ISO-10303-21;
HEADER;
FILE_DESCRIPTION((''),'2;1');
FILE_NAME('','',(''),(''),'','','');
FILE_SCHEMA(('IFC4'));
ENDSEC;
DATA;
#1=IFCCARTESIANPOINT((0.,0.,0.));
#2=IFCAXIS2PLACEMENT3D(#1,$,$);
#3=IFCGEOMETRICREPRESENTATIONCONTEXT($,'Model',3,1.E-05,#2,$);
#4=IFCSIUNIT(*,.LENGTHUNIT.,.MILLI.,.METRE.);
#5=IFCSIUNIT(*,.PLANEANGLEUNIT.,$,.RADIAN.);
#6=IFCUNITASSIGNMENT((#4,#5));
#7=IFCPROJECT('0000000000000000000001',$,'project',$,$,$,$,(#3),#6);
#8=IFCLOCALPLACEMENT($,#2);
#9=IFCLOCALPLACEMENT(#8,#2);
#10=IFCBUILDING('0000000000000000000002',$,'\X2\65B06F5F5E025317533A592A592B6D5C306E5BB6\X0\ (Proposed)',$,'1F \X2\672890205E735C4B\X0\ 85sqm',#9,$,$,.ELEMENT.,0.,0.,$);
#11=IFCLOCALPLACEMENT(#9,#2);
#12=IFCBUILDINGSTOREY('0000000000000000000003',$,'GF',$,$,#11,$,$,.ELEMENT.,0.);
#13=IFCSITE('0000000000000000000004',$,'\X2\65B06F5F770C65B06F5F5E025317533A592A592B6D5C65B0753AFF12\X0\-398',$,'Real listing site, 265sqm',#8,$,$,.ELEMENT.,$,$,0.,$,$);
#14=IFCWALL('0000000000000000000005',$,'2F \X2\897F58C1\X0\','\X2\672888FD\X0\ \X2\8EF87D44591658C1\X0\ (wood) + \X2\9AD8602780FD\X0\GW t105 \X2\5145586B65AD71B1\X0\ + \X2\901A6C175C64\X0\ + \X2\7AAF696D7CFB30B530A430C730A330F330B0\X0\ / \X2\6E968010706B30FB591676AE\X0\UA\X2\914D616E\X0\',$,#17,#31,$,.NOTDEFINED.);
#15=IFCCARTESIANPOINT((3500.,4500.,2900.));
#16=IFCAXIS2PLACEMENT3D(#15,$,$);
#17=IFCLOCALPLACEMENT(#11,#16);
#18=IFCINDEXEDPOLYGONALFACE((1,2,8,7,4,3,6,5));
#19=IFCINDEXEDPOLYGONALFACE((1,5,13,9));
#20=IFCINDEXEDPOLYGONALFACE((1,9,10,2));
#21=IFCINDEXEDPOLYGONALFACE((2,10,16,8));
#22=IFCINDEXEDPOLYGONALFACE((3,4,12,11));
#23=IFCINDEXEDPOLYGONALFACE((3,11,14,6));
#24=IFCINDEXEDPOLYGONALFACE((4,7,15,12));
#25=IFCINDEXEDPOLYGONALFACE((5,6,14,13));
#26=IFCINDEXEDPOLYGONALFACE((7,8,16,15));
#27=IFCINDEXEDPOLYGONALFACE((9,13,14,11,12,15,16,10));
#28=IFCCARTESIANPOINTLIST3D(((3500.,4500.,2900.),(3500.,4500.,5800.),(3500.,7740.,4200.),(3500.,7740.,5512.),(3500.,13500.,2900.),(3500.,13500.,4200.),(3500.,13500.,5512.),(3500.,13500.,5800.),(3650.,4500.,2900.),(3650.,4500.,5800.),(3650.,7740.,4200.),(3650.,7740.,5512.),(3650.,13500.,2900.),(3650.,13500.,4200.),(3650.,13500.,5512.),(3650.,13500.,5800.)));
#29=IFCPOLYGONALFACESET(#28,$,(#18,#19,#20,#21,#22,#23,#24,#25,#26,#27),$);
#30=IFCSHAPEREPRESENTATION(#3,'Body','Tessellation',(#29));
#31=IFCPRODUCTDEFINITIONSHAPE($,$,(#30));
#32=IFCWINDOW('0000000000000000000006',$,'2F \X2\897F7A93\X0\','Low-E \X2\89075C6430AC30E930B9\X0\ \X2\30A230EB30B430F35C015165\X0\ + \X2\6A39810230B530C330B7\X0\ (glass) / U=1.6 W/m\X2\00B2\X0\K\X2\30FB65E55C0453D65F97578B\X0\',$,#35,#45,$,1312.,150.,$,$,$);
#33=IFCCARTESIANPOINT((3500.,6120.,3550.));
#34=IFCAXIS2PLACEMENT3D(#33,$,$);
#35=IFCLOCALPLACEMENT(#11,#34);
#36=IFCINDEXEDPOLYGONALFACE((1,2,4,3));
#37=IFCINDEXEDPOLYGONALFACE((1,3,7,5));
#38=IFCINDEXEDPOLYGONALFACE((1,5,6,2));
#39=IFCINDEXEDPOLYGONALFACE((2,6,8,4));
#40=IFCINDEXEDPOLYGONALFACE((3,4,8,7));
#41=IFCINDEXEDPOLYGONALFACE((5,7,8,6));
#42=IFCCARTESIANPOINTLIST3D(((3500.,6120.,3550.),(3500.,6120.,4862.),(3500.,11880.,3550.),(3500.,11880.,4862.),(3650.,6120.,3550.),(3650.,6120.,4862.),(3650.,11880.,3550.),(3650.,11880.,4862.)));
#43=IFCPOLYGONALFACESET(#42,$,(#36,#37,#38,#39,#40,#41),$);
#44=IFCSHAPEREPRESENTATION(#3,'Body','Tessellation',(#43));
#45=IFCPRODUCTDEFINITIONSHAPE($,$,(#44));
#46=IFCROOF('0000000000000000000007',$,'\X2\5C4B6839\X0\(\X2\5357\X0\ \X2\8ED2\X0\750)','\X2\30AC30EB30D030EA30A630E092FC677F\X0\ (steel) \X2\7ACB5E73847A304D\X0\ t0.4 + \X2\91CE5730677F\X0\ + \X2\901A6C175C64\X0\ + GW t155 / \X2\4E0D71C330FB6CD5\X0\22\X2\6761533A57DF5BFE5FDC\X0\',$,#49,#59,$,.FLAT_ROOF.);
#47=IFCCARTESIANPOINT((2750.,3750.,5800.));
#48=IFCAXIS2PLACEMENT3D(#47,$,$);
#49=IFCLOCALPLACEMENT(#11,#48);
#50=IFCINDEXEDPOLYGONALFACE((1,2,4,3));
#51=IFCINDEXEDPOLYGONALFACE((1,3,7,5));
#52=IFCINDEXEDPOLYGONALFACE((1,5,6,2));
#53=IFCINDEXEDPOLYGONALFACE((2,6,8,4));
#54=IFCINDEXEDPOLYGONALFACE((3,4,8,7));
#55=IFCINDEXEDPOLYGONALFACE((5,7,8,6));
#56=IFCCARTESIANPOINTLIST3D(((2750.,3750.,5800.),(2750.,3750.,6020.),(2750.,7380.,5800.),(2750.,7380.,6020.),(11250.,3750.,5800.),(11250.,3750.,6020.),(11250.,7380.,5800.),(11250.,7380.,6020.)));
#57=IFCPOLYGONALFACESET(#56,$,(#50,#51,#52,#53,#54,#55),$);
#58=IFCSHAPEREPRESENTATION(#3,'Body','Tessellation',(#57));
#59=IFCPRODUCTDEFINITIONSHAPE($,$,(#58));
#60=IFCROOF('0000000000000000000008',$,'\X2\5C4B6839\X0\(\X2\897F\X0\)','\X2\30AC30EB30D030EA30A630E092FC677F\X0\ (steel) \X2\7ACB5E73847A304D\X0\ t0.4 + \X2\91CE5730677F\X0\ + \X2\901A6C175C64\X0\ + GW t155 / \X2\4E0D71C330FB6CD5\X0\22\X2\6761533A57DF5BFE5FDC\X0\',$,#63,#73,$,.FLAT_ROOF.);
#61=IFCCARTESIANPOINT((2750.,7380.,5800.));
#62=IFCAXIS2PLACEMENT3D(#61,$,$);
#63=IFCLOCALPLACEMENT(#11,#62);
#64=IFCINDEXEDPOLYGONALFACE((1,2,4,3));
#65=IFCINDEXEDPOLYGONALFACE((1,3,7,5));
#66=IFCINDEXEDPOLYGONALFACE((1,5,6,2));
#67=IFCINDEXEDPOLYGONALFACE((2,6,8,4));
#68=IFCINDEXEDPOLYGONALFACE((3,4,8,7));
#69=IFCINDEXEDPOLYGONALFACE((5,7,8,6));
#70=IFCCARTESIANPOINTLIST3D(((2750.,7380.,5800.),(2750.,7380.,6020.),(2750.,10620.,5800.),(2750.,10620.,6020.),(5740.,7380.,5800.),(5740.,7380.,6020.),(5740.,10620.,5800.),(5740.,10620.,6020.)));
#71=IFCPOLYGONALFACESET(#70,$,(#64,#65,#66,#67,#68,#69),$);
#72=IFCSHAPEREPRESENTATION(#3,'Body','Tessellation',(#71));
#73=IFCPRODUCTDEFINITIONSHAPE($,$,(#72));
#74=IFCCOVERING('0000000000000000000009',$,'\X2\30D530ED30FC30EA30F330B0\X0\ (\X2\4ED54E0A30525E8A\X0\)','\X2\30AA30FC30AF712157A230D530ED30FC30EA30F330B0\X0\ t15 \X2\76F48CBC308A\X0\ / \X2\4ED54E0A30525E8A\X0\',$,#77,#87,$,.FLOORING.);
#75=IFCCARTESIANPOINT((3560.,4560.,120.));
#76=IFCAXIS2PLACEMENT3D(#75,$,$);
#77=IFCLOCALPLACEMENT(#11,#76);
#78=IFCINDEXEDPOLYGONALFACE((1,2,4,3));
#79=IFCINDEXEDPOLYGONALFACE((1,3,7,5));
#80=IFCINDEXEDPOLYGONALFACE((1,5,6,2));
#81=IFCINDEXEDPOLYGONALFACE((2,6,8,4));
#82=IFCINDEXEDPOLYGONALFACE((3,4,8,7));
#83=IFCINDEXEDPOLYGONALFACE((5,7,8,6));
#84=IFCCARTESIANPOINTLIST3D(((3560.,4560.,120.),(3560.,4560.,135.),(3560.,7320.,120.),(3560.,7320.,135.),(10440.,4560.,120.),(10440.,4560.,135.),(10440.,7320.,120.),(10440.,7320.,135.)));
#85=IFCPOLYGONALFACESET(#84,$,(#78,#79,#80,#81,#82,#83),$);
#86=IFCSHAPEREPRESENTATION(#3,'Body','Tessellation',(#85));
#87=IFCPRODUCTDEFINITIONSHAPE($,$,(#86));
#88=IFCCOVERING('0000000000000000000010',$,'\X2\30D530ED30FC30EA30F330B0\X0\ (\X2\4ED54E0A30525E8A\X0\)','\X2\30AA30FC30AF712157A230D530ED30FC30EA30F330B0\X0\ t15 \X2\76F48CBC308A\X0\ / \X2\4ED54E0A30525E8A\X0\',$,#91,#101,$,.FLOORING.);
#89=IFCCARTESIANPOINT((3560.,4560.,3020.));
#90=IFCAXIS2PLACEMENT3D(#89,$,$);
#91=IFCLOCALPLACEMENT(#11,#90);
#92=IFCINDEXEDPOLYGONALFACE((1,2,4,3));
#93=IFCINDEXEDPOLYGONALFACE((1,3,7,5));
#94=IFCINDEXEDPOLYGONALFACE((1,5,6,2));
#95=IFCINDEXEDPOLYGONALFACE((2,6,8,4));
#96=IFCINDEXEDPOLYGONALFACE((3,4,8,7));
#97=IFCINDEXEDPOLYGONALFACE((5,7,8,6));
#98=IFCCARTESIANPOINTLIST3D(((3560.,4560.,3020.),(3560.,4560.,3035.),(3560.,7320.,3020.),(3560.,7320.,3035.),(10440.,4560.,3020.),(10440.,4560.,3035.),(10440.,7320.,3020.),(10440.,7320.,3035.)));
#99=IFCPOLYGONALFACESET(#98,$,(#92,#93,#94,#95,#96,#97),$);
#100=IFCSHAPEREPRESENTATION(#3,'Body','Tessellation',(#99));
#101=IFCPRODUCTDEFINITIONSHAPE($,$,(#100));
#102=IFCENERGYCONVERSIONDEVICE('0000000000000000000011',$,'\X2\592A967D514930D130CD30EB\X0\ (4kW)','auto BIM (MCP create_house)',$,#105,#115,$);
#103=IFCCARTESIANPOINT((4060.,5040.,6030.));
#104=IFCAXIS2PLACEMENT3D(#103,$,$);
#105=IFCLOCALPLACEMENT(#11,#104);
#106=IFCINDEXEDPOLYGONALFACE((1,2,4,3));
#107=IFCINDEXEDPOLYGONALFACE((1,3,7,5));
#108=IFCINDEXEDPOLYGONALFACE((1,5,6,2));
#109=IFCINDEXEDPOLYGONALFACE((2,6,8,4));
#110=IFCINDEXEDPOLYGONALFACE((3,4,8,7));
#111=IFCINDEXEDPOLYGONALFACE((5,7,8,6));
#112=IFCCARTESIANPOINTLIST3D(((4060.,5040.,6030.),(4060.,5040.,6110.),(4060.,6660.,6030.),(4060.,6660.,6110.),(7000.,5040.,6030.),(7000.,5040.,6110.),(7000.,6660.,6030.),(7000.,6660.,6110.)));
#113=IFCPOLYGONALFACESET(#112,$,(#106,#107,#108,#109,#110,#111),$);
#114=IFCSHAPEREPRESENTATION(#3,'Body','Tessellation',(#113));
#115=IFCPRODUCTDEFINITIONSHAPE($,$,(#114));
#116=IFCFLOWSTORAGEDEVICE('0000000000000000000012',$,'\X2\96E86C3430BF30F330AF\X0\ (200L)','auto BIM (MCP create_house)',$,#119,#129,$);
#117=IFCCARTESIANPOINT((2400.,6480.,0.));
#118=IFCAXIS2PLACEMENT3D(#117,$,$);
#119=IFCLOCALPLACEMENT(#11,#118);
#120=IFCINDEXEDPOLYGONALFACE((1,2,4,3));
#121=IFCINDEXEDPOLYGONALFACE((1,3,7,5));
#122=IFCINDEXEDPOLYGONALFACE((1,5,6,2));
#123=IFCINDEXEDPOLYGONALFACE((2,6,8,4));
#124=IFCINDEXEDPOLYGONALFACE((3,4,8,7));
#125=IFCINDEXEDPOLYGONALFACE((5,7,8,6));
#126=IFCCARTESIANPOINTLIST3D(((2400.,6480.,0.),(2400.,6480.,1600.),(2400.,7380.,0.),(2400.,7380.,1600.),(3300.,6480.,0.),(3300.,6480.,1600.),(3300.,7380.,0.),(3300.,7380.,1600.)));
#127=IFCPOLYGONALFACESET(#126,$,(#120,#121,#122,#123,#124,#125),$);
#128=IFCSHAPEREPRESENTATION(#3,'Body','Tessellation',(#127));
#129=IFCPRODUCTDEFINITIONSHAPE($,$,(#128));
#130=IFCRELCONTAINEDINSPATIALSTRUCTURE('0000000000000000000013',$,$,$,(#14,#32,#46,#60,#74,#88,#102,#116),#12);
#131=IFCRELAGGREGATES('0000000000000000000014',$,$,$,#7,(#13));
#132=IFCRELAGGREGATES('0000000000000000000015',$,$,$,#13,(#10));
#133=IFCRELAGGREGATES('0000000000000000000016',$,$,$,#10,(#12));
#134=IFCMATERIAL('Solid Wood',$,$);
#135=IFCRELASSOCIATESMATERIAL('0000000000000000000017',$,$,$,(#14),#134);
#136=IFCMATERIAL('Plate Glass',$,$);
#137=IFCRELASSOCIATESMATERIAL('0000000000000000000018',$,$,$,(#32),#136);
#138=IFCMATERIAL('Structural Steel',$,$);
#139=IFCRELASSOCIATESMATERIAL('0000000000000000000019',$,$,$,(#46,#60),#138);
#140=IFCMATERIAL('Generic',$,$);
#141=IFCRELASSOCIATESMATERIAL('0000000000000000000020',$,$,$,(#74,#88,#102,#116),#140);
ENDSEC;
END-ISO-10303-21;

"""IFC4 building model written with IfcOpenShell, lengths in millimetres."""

from ifc_helpers import new_model, si_unit, frame, frame_2d, origin, place, context, project, spatial, rectangle, extrude, material, element, fill, save


model = new_model("IFC4")

# Units and contexts
model_context = context("Model", 3, precision=1e-05, world=origin())
ifc_project = project(units=[si_unit("LENGTHUNIT", "METRE", prefix="MILLI"), si_unit("PLANEANGLEUNIT", "RADIAN")], contexts=[model_context])

# Site, building, storey
site_placement = place(None, origin())
site = spatial("IfcSite", under=ifc_project, at=site_placement, Name="新潟県新潟市北区太夫浜新町２-398", ObjectType="Real listing site, 265sqm", CompositionType="ELEMENT", RefElevation=0.0)
building_placement = place(site_placement, origin())
building = spatial("IfcBuilding", under=site, at=building_placement, Name="新潟市北区太夫浜の家 (Proposed)", ObjectType="1F 木造平屋 85sqm", CompositionType="ELEMENT", ElevationOfRefHeight=0.0, ElevationOfTerrain=0.0)
storey_placement = place(building_placement, origin())
storey = spatial("IfcBuildingStorey", under=building, at=storey_placement, Name="GF", CompositionType="ELEMENT", Elevation=0.0)

# Shared definitions
ifc_material_1 = material(Name="Solid Wood")
ifc_material_2 = material(Name="Generic")

# Shared definitions
ifc_material_3 = material(Name="Plate Glass")

# Wall, opening, window
wall_1_placement = place(storey_placement, frame((3500.0, 4500.0, 2900.0)))
wall_1 = element("IfcWall", 1, at=wall_1_placement, inside=storey, material=ifc_material_1, Name="2F 西壁", Description="木製 軸組外壁 (wood) + 高性能GW t105 充填断熱 + 通気層 + 窯業系サイディング / 準耐火・外皮UA配慮", PredefinedType="NOTDEFINED", context=model_context, shape_type="SweptSolid", body=[
    extrude(rectangle(XDim=150.0, YDim=9000.0, at=frame_2d((75.0, 4500.0))), frame((3500.0, 4500.0, 2900.0)), (0.0, 0.0, 1.0), 2900.0),
])
opening_1_placement = place(storey_placement, frame((3500.0, 6120.0, 3550.0)))
opening_1 = element("IfcOpeningElement", 2, at=opening_1_placement, cuts=wall_1, PredefinedType="NOTDEFINED", context=model_context, shape_type="SweptSolid", body=[
    extrude(rectangle(XDim=150.0, YDim=5760.0, at=frame_2d((75.0, 2880.0))), frame((3500.0, 6120.0, 3550.0)), (0.0, 0.0, 1.0), 1312.0),
])
window_1_placement = place(storey_placement, frame((3500.0, 6120.0, 3550.0)))
window_1 = element("IfcWindow", 3, at=window_1_placement, inside=storey, material=ifc_material_3, Name="2F 西窓", Description="Low-E 複層ガラス アルゴン封入 + 樹脂サッシ (glass) / U=1.6 W/m²K・日射取得型", OverallHeight=1312.0, OverallWidth=150.0, context=model_context, shape_type="SweptSolid", body=[
    extrude(rectangle(XDim=150.0, YDim=5760.0, at=frame_2d((75.0, 2880.0))), frame((3500.0, 6120.0, 3550.0)), (0.0, 0.0, 1.0), 1312.0),
])
fill(opening_1, window_1)

# Roofs
ifc_material_4 = material(Name="Structural Steel")
roof_1_placement = place(storey_placement, frame((2750.0, 3750.0, 5800.0)))
element("IfcRoof", 4, at=roof_1_placement, inside=storey, material=ifc_material_4, Name="屋根(南 軒750)", Description="ガルバリウム鋼板 (steel) 立平葺き t0.4 + 野地板 + 通気層 + GW t155 / 不燃・法22条区域対応", PredefinedType="FLAT_ROOF", context=model_context, shape_type="SweptSolid", body=[
    extrude(rectangle(XDim=8500.0, YDim=3630.0, at=frame_2d((4250.0, 1815.0))), frame((2750.0, 3750.0, 5800.0)), (0.0, 0.0, 1.0), 220.0),
])
roof_2_placement = place(storey_placement, frame((2750.0, 7380.0, 5800.0)))
element("IfcRoof", 5, at=roof_2_placement, inside=storey, material=ifc_material_4, Name="屋根(西)", Description="ガルバリウム鋼板 (steel) 立平葺き t0.4 + 野地板 + 通気層 + GW t155 / 不燃・法22条区域対応", PredefinedType="FLAT_ROOF", context=model_context, shape_type="SweptSolid", body=[
    extrude(rectangle(XDim=2990.0, YDim=3240.0, at=frame_2d((1495.0, 1620.0))), frame((2750.0, 7380.0, 5800.0)), (0.0, 0.0, 1.0), 220.0),
])

# Coverings
covering_1_placement = place(storey_placement, frame((3560.0, 4560.0, 120.0)))
element("IfcCovering", 6, at=covering_1_placement, inside=storey, material=ifc_material_2, Name="フローリング (仕上げ床)", Description="オーク無垢フローリング t15 直貼り / 仕上げ床", PredefinedType="FLOORING", context=model_context, shape_type="SweptSolid", body=[
    extrude(rectangle(XDim=6880.0, YDim=2760.0, at=frame_2d((3440.0, 1380.0))), frame((3560.0, 4560.0, 120.0)), (0.0, 0.0, 1.0), 15.0),
])
covering_2_placement = place(storey_placement, frame((3560.0, 4560.0, 3020.0)))
element("IfcCovering", 7, at=covering_2_placement, inside=storey, material=ifc_material_2, Name="フローリング (仕上げ床)", Description="オーク無垢フローリング t15 直貼り / 仕上げ床", PredefinedType="FLOORING", context=model_context, shape_type="SweptSolid", body=[
    extrude(rectangle(XDim=6880.0, YDim=2760.0, at=frame_2d((3440.0, 1380.0))), frame((3560.0, 4560.0, 3020.0)), (0.0, 0.0, 1.0), 15.0),
])

# Energy conversion device
energy_conversion_device_placement = place(storey_placement, frame((4060.0, 5040.0, 6030.0)))
element("IfcEnergyConversionDevice", 8, at=energy_conversion_device_placement, inside=storey, material=ifc_material_2, Name="太陽光パネル (4kW)", Description="auto BIM (MCP create_house)", context=model_context, shape_type="SweptSolid", body=[
    extrude(rectangle(XDim=2940.0, YDim=1620.0, at=frame_2d((1470.0, 810.0))), frame((4060.0, 5040.0, 6030.0)), (0.0, 0.0, 1.0), 80.0),
])

# Flow storage device
flow_storage_device_placement = place(storey_placement, frame((2400.0, 6480.0, 0.0)))
element("IfcFlowStorageDevice", 9, at=flow_storage_device_placement, inside=storey, material=ifc_material_2, Name="雨水タンク (200L)", Description="auto BIM (MCP create_house)", context=model_context, shape_type="SweptSolid", body=[
    extrude(rectangle(XDim=900.0, YDim=900.0, at=frame_2d((450.0, 450.0))), frame((2400.0, 6480.0, 0.0)), (0.0, 0.0, 1.0), 1600.0),
])

save(model, "model.ifc")
